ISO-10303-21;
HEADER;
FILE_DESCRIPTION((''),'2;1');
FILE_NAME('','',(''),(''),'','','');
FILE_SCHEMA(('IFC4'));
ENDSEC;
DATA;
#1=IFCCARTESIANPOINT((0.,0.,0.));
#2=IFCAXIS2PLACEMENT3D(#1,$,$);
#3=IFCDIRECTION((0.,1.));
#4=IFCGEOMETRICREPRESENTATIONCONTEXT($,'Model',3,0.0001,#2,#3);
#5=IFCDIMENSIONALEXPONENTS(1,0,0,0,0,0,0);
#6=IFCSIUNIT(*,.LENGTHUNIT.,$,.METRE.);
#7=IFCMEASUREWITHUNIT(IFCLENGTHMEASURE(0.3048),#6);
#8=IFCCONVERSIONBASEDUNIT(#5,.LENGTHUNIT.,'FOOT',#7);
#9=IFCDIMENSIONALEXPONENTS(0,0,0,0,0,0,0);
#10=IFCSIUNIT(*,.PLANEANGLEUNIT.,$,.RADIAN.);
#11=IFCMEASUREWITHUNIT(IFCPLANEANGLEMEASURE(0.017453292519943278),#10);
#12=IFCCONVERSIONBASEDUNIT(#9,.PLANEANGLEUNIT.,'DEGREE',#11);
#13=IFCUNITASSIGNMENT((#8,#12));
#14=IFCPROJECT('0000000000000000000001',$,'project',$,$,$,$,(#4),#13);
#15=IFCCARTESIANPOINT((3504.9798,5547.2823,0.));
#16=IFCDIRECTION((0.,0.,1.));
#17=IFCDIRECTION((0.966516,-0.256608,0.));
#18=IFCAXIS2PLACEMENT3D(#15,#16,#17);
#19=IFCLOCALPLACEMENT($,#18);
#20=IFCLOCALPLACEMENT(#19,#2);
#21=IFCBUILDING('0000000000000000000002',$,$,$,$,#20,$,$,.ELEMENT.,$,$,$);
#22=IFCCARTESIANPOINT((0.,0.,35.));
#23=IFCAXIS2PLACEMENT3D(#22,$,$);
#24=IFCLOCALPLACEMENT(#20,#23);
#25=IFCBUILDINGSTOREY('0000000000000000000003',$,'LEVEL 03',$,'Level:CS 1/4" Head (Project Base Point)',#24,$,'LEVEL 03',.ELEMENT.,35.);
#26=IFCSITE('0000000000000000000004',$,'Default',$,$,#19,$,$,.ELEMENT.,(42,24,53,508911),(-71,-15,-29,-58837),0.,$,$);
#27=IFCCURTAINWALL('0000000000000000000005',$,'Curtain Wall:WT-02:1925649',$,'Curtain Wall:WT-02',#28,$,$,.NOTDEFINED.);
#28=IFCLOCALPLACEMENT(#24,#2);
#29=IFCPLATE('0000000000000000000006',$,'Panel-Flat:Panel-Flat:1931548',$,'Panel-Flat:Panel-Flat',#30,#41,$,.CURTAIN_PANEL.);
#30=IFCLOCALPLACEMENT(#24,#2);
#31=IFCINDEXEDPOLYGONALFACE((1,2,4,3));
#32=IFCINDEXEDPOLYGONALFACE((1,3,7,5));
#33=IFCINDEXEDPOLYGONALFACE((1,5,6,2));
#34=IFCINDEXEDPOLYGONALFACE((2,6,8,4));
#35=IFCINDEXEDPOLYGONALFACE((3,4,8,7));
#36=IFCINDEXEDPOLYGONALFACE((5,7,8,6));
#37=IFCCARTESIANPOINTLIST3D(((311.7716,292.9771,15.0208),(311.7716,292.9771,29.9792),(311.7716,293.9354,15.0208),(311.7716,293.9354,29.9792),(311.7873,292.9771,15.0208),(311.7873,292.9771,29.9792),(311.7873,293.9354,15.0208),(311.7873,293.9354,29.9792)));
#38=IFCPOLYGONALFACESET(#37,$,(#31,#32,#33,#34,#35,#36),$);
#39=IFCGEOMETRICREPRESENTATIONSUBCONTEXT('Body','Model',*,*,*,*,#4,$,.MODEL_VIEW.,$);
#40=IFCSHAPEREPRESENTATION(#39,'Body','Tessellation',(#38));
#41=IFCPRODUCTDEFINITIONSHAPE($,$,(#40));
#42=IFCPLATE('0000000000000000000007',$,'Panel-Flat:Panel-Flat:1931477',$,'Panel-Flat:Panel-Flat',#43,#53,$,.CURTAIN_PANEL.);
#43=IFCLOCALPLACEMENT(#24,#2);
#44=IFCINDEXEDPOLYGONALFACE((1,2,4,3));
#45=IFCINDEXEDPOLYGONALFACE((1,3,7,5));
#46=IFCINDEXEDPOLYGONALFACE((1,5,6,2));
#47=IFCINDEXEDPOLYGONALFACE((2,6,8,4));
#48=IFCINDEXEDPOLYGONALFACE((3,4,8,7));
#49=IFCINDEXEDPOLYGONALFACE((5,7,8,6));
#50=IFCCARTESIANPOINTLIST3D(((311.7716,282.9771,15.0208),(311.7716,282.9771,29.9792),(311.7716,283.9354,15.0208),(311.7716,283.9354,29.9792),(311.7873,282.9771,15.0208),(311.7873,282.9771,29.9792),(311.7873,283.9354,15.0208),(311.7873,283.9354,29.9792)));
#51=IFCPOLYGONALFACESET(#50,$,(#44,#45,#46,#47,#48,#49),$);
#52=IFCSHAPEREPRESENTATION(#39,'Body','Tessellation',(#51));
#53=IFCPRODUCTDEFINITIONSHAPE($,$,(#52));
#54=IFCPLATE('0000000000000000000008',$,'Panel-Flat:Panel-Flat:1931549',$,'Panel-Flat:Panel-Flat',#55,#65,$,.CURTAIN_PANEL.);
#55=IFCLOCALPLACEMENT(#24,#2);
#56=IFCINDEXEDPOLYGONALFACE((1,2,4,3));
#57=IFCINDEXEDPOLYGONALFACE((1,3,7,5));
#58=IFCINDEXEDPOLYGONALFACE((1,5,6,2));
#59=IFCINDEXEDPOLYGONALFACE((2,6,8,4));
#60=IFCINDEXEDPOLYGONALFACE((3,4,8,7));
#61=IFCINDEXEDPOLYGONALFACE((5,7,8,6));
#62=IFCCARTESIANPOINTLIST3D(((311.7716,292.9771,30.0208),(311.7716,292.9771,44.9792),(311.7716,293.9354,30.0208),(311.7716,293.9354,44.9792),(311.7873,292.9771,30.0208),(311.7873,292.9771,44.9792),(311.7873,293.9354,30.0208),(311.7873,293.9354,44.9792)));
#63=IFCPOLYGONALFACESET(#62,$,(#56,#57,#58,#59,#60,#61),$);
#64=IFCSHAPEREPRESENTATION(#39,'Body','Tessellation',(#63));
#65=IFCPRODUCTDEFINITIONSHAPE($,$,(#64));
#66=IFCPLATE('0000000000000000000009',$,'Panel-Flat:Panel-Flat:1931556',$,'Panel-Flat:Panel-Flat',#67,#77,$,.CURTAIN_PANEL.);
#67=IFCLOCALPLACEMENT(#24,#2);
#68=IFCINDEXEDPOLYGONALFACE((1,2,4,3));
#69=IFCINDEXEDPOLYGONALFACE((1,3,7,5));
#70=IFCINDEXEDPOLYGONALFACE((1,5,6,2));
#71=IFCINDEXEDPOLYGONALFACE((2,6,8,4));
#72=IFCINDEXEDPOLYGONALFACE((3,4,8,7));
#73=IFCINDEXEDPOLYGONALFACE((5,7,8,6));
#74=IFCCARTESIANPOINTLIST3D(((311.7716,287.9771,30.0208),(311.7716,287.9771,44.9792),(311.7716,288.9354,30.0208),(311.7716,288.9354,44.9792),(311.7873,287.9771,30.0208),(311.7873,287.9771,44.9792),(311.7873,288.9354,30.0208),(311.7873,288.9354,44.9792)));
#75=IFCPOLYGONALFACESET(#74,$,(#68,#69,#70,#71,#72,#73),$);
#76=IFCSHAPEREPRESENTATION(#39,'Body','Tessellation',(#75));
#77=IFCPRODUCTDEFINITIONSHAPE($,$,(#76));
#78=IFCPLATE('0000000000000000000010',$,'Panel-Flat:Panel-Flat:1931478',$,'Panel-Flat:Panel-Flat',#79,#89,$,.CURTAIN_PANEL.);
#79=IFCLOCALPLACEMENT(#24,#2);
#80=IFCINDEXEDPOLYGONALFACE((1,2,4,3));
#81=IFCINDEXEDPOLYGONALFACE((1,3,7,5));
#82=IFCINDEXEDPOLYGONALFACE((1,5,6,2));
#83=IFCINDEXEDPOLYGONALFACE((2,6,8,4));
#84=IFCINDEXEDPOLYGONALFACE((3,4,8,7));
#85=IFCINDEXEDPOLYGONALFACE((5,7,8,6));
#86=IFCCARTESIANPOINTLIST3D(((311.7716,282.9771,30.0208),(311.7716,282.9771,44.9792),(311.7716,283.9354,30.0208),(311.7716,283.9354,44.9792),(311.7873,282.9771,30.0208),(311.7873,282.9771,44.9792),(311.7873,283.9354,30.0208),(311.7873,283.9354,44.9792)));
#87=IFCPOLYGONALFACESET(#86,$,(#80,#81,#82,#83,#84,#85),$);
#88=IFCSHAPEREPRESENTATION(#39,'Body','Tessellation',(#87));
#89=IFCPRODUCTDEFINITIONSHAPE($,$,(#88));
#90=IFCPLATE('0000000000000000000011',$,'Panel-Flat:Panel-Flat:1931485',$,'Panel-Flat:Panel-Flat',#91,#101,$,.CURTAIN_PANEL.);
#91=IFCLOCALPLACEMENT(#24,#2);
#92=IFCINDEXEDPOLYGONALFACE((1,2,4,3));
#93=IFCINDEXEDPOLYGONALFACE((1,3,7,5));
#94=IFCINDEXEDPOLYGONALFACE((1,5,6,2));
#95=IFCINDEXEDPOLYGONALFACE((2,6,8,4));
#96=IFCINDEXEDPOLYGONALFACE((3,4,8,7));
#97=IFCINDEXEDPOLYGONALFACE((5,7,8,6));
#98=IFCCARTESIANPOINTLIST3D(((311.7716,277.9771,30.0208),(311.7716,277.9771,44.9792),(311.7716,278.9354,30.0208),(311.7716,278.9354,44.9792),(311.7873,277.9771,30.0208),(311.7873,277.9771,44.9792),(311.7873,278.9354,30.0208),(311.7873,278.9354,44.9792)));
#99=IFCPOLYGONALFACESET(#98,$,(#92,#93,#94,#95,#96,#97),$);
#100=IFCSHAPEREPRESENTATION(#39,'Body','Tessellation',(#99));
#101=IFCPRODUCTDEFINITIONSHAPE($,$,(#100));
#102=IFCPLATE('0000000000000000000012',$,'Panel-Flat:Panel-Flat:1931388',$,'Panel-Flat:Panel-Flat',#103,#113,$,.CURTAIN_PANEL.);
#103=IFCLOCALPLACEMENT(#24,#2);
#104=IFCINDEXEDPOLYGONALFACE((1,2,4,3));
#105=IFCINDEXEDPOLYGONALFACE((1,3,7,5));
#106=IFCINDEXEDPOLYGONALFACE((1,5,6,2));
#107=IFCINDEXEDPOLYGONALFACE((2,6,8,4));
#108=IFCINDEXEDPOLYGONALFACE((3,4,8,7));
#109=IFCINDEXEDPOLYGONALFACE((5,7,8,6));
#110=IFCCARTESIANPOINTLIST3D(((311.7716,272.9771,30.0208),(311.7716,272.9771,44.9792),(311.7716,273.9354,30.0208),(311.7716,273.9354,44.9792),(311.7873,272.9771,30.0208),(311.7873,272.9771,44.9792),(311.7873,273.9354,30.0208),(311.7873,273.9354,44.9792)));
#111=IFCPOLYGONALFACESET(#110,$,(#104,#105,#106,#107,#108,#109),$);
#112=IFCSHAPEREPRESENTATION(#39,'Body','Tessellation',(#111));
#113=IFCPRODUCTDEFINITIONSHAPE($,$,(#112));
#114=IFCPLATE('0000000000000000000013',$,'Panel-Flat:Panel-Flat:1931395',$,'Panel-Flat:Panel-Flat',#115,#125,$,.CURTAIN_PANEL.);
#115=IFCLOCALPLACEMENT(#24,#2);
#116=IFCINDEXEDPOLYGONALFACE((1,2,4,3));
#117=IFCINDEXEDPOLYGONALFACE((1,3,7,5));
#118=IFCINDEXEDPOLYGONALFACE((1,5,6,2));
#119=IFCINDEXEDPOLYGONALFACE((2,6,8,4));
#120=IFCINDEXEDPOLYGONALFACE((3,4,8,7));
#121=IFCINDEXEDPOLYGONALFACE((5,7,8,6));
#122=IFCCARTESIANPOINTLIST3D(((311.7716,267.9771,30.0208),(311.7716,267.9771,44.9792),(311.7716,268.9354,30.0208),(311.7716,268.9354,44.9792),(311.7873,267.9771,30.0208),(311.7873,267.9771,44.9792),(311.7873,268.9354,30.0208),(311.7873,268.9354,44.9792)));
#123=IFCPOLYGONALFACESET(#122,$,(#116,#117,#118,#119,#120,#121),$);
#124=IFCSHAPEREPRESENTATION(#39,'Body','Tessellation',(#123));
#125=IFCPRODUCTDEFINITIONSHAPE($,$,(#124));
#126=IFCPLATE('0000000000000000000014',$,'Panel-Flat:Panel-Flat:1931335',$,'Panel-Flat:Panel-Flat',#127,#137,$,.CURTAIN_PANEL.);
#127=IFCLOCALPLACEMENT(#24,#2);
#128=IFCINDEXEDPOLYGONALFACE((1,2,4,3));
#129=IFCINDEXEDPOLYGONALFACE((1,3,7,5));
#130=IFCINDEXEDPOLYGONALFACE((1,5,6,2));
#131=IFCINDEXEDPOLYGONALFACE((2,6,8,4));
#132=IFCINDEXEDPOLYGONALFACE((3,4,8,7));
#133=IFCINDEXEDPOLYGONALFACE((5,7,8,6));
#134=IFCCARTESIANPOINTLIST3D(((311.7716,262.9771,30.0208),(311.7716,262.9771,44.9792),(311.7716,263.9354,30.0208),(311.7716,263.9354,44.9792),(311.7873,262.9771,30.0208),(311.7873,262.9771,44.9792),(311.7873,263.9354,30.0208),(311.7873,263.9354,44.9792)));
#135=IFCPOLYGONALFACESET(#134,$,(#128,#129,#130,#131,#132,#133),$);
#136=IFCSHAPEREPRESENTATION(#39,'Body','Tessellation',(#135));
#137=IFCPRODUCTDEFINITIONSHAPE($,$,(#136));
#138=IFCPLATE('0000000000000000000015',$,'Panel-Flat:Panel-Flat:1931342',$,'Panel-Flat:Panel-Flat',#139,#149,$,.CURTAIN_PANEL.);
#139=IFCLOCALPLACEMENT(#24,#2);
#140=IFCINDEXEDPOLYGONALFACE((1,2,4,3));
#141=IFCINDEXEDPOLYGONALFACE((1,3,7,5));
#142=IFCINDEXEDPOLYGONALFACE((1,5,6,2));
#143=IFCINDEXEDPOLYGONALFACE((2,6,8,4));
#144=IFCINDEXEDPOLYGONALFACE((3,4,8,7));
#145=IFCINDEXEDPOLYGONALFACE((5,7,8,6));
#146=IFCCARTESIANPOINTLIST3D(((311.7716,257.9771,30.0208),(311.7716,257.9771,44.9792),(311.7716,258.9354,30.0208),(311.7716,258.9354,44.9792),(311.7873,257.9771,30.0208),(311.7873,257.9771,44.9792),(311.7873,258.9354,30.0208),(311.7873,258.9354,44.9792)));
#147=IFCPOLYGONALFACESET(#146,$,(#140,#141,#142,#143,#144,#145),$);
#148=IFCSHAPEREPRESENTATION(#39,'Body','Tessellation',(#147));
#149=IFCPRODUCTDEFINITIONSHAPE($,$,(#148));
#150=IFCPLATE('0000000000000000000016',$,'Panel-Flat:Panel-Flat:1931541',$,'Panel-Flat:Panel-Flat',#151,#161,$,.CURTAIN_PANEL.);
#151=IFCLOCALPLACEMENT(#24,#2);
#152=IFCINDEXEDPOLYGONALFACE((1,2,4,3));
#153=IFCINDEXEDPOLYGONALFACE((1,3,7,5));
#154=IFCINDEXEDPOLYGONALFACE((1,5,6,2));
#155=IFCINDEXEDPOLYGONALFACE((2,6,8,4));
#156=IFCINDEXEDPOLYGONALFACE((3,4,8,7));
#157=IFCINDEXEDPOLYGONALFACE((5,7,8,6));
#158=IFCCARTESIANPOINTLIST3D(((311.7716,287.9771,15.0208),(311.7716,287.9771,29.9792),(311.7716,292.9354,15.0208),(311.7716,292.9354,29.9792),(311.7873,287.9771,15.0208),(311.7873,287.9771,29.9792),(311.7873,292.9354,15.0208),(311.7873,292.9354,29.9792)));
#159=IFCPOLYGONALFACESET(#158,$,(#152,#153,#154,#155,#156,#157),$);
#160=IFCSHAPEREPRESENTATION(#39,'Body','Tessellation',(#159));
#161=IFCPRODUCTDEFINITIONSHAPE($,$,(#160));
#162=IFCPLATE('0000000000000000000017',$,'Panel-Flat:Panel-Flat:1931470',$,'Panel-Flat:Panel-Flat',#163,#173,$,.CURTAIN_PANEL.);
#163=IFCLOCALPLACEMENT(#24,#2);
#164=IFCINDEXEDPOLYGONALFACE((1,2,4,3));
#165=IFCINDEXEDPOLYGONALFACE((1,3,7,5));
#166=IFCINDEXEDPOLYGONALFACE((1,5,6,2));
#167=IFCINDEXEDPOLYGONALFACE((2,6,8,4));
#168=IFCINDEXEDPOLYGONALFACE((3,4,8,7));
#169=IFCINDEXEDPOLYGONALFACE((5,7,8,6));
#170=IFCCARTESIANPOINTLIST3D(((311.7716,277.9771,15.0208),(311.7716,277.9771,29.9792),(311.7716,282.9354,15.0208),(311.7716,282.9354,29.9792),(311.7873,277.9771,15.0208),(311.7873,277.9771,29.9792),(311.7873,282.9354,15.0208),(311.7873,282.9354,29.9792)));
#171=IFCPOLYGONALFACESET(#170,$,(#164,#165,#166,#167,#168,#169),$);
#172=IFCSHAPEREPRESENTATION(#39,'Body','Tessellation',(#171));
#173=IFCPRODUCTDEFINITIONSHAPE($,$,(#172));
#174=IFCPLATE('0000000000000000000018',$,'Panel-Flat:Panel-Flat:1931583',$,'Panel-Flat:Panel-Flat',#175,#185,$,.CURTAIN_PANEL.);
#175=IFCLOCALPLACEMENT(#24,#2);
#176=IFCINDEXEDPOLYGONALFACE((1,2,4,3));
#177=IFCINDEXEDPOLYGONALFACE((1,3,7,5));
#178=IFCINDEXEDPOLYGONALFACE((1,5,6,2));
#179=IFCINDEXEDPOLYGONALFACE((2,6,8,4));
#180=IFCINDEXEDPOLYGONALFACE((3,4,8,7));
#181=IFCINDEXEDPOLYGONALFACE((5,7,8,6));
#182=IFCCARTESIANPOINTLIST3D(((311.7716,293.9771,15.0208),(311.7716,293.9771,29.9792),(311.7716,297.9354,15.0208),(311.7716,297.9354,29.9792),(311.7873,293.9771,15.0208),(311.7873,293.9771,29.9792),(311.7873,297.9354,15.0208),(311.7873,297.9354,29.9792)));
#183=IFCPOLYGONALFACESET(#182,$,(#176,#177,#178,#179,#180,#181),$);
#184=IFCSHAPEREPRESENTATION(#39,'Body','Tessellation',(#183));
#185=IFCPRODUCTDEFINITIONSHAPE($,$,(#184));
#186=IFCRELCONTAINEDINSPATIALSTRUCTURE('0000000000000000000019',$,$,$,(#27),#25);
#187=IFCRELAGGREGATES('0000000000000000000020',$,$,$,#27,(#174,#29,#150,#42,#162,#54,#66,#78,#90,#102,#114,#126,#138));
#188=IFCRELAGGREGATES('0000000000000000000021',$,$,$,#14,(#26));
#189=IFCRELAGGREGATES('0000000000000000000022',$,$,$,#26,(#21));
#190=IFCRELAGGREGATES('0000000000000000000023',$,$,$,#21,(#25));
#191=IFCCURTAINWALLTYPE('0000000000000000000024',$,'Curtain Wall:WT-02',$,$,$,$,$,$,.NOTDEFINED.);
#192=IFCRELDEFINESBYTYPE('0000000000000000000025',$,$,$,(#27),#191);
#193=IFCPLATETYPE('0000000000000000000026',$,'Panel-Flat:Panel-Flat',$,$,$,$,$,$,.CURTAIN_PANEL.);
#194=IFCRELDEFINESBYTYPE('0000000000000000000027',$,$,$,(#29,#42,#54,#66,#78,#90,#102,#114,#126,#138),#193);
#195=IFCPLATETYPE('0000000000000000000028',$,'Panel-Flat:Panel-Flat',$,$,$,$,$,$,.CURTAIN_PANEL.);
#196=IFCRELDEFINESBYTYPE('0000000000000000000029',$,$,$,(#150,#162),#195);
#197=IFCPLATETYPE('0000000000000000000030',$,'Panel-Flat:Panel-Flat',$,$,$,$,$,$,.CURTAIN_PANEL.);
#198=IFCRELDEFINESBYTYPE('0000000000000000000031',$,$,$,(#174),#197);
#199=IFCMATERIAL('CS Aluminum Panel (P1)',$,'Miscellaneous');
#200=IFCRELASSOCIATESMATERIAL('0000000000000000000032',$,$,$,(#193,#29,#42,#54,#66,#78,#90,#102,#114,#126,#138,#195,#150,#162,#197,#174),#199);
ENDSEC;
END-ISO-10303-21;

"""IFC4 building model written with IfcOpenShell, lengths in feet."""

from ifc_helpers import new_model, entity, si_unit, converted_unit, direction, frame, origin, place, context, subcontext, project, spatial, indexed_curve, outline, extrude, source, transform, mapped, material, type_object, type_shapes, element, aggregate, save


model = new_model("IFC4")

# Units and contexts
model_context = context("Model", 3, precision=0.0001, world=origin(), true_north=direction((0.0, 1.0)))
body_context = subcontext(model_context, "Body", "Model", "MODEL_VIEW")
ifc_project = project(units=[converted_unit("LENGTHUNIT", "FOOT", entity("IfcLengthMeasure", 0.3048), si_unit("LENGTHUNIT", "METRE"), dimensions=[1, 0, 0, 0, 0, 0, 0]), converted_unit("PLANEANGLEUNIT", "DEGREE", entity("IfcPlaneAngleMeasure", 0.017453292519943278), si_unit("PLANEANGLEUNIT", "RADIAN"), dimensions=[0, 0, 0, 0, 0, 0, 0])], contexts=[model_context])

# Site, building, storey
site_placement = place(None, frame((3504.9798, 5547.2823, 0.0), z_axis=(0.0, 0.0, 1.0), x_axis=(0.966516, -0.256608, 0.0)))
site = spatial("IfcSite", under=ifc_project, at=site_placement, Name="Default", CompositionType="ELEMENT", RefLatitude=(42, 24, 53, 508911), RefLongitude=(-71, -15, -29, -58837), RefElevation=0.0)
building_placement = place(site_placement, origin())
building = spatial("IfcBuilding", under=site, at=building_placement, CompositionType="ELEMENT")
storey_placement = place(building_placement, frame((0.0, 0.0, 35.0)))
storey = spatial("IfcBuildingStorey", under=building, at=storey_placement, Name="LEVEL 03", ObjectType="Level:CS 1/4\" Head (Project Base Point)", LongName="LEVEL 03", CompositionType="ELEMENT", Elevation=35.0)

# Curtain wall, plates
curtain_wall_type = type_object("IfcCurtainWallType", Name="Curtain Wall:WT-02", PredefinedType="NOTDEFINED")
curtain_wall_placement = place(storey_placement, frame((0.0, 0.0, -35.0)))
curtain_wall = element("IfcCurtainWall", 1, at=curtain_wall_placement, inside=storey, type_object=curtain_wall_type, Name="Curtain Wall:WT-02:1925649", ObjectType="Curtain Wall:WT-02", PredefinedType="NOTDEFINED")
ifc_material = material(Name="CS Aluminum Panel (P1)", Category="Miscellaneous")
plate_type_1 = type_object("IfcPlateType", Name="Panel-Flat:Panel-Flat", PredefinedType="CURTAIN_PANEL", material=ifc_material)
shared_shape_1 = source(origin(), body_context, "Body", "SweptSolid", [
    extrude(outline(indexed_curve([(-0.0078, -0.4792), (0.0078, -0.4792), (0.0078, 0.4792), (-0.0078, 0.4792), (-0.0078, -0.4792)], self_intersect=False)), frame((0.0, -0.0078, 0.0208), z_axis=(0.0, 0.0, 1.0), x_axis=(0.0, -1.0, 0.0)), (0.0, 0.0, 1.0), 14.9583),
])
type_shapes(plate_type_1, [shared_shape_1])
plate_1_placement = place(curtain_wall_placement, frame((311.7873, 293.4563, 50.0), z_axis=(0.0, 0.0, 1.0), x_axis=(0.0, -1.0, 0.0)))
plate_1 = element("IfcPlate", 2, at=plate_1_placement, type_object=plate_type_1, material=ifc_material, Name="Panel-Flat:Panel-Flat:1931548", ObjectType="Panel-Flat:Panel-Flat", PredefinedType="CURTAIN_PANEL", context=body_context, shape_type="MappedRepresentation", body=[
    mapped(shared_shape_1, transform((0.0, 0.0, 0.0), scale=1.0)),
])
plate_2_placement = place(curtain_wall_placement, frame((311.7873, 283.4563, 50.0), z_axis=(0.0, 0.0, 1.0), x_axis=(0.0, -1.0, 0.0)))
plate_2 = element("IfcPlate", 3, at=plate_2_placement, type_object=plate_type_1, material=ifc_material, Name="Panel-Flat:Panel-Flat:1931477", ObjectType="Panel-Flat:Panel-Flat", PredefinedType="CURTAIN_PANEL", context=body_context, shape_type="MappedRepresentation", body=[
    mapped(shared_shape_1, transform((0.0, 0.0, 0.0), scale=1.0)),
])
plate_3_placement = place(curtain_wall_placement, frame((311.7873, 293.4563, 65.0), z_axis=(0.0, 0.0, 1.0), x_axis=(0.0, -1.0, 0.0)))
plate_3 = element("IfcPlate", 4, at=plate_3_placement, type_object=plate_type_1, material=ifc_material, Name="Panel-Flat:Panel-Flat:1931549", ObjectType="Panel-Flat:Panel-Flat", PredefinedType="CURTAIN_PANEL", context=body_context, shape_type="MappedRepresentation", body=[
    mapped(shared_shape_1, transform((0.0, 0.0, 0.0), scale=1.0)),
])
plate_4_placement = place(curtain_wall_placement, frame((311.7873, 288.4563, 65.0), z_axis=(0.0, 0.0, 1.0), x_axis=(0.0, -1.0, 0.0)))
plate_4 = element("IfcPlate", 5, at=plate_4_placement, type_object=plate_type_1, material=ifc_material, Name="Panel-Flat:Panel-Flat:1931556", ObjectType="Panel-Flat:Panel-Flat", PredefinedType="CURTAIN_PANEL", context=body_context, shape_type="MappedRepresentation", body=[
    mapped(shared_shape_1, transform((0.0, 0.0, 0.0), scale=1.0)),
])
plate_5_placement = place(curtain_wall_placement, frame((311.7873, 283.4563, 65.0), z_axis=(0.0, 0.0, 1.0), x_axis=(0.0, -1.0, 0.0)))
plate_5 = element("IfcPlate", 6, at=plate_5_placement, type_object=plate_type_1, material=ifc_material, Name="Panel-Flat:Panel-Flat:1931478", ObjectType="Panel-Flat:Panel-Flat", PredefinedType="CURTAIN_PANEL", context=body_context, shape_type="MappedRepresentation", body=[
    mapped(shared_shape_1, transform((0.0, 0.0, 0.0), scale=1.0)),
])
plate_6_placement = place(curtain_wall_placement, frame((311.7873, 278.4563, 65.0), z_axis=(0.0, 0.0, 1.0), x_axis=(0.0, -1.0, 0.0)))
plate_6 = element("IfcPlate", 7, at=plate_6_placement, type_object=plate_type_1, material=ifc_material, Name="Panel-Flat:Panel-Flat:1931485", ObjectType="Panel-Flat:Panel-Flat", PredefinedType="CURTAIN_PANEL", context=body_context, shape_type="MappedRepresentation", body=[
    mapped(shared_shape_1, transform((0.0, 0.0, 0.0), scale=1.0)),
])
plate_7_placement = place(curtain_wall_placement, frame((311.7873, 273.4563, 65.0), z_axis=(0.0, 0.0, 1.0), x_axis=(0.0, -1.0, 0.0)))
plate_7 = element("IfcPlate", 8, at=plate_7_placement, type_object=plate_type_1, material=ifc_material, Name="Panel-Flat:Panel-Flat:1931388", ObjectType="Panel-Flat:Panel-Flat", PredefinedType="CURTAIN_PANEL", context=body_context, shape_type="MappedRepresentation", body=[
    mapped(shared_shape_1, transform((0.0, 0.0, 0.0), scale=1.0)),
])
plate_8_placement = place(curtain_wall_placement, frame((311.7873, 268.4563, 65.0), z_axis=(0.0, 0.0, 1.0), x_axis=(0.0, -1.0, 0.0)))
plate_8 = element("IfcPlate", 9, at=plate_8_placement, type_object=plate_type_1, material=ifc_material, Name="Panel-Flat:Panel-Flat:1931395", ObjectType="Panel-Flat:Panel-Flat", PredefinedType="CURTAIN_PANEL", context=body_context, shape_type="MappedRepresentation", body=[
    mapped(shared_shape_1, transform((0.0, 0.0, 0.0), scale=1.0)),
])
plate_9_placement = place(curtain_wall_placement, frame((311.7873, 263.4563, 65.0), z_axis=(0.0, 0.0, 1.0), x_axis=(0.0, -1.0, 0.0)))
plate_9 = element("IfcPlate", 10, at=plate_9_placement, type_object=plate_type_1, material=ifc_material, Name="Panel-Flat:Panel-Flat:1931335", ObjectType="Panel-Flat:Panel-Flat", PredefinedType="CURTAIN_PANEL", context=body_context, shape_type="MappedRepresentation", body=[
    mapped(shared_shape_1, transform((0.0, 0.0, 0.0), scale=1.0)),
])
plate_10_placement = place(curtain_wall_placement, frame((311.7873, 258.4563, 65.0), z_axis=(0.0, 0.0, 1.0), x_axis=(0.0, -1.0, 0.0)))
plate_10 = element("IfcPlate", 11, at=plate_10_placement, type_object=plate_type_1, material=ifc_material, Name="Panel-Flat:Panel-Flat:1931342", ObjectType="Panel-Flat:Panel-Flat", PredefinedType="CURTAIN_PANEL", context=body_context, shape_type="MappedRepresentation", body=[
    mapped(shared_shape_1, transform((0.0, 0.0, 0.0), scale=1.0)),
])
plate_type_2 = type_object("IfcPlateType", Name="Panel-Flat:Panel-Flat", PredefinedType="CURTAIN_PANEL", material=ifc_material)
shared_shape_2 = source(origin(), body_context, "Body", "SweptSolid", [
    extrude(outline(indexed_curve([(-0.0078, -2.4792), (0.0078, -2.4792), (0.0078, 2.4792), (-0.0078, 2.4792), (-0.0078, -2.4792)], self_intersect=False)), frame((0.0, -0.0078, 0.0208), z_axis=(0.0, 0.0, 1.0), x_axis=(0.0, -1.0, 0.0)), (0.0, 0.0, 1.0), 14.9583),
])
type_shapes(plate_type_2, [shared_shape_2])
plate_11_placement = place(curtain_wall_placement, frame((311.7873, 290.4563, 50.0), z_axis=(0.0, 0.0, 1.0), x_axis=(0.0, -1.0, 0.0)))
plate_11 = element("IfcPlate", 12, at=plate_11_placement, type_object=plate_type_2, material=ifc_material, Name="Panel-Flat:Panel-Flat:1931541", ObjectType="Panel-Flat:Panel-Flat", PredefinedType="CURTAIN_PANEL", context=body_context, shape_type="MappedRepresentation", body=[
    mapped(shared_shape_2, transform((0.0, 0.0, 0.0), scale=1.0)),
])
plate_12_placement = place(curtain_wall_placement, frame((311.7873, 280.4563, 50.0), z_axis=(0.0, 0.0, 1.0), x_axis=(0.0, -1.0, 0.0)))
plate_12 = element("IfcPlate", 13, at=plate_12_placement, type_object=plate_type_2, material=ifc_material, Name="Panel-Flat:Panel-Flat:1931470", ObjectType="Panel-Flat:Panel-Flat", PredefinedType="CURTAIN_PANEL", context=body_context, shape_type="MappedRepresentation", body=[
    mapped(shared_shape_2, transform((0.0, 0.0, 0.0), scale=1.0)),
])
plate_type_3 = type_object("IfcPlateType", Name="Panel-Flat:Panel-Flat", PredefinedType="CURTAIN_PANEL", material=ifc_material)
shared_shape_3 = source(origin(), body_context, "Body", "SweptSolid", [
    extrude(outline(indexed_curve([(-0.0078, -1.9792), (0.0078, -1.9792), (0.0078, 1.9792), (-0.0078, 1.9792), (-0.0078, -1.9792)], self_intersect=False)), frame((0.0, -0.0078, 0.0208), z_axis=(0.0, 0.0, 1.0), x_axis=(0.0, -1.0, 0.0)), (0.0, 0.0, 1.0), 14.9583),
])
type_shapes(plate_type_3, [shared_shape_3])
plate_13_placement = place(curtain_wall_placement, frame((311.7873, 295.9563, 50.0), z_axis=(0.0, 0.0, 1.0), x_axis=(0.0, -1.0, 0.0)))
plate_13 = element("IfcPlate", 14, at=plate_13_placement, type_object=plate_type_3, material=ifc_material, Name="Panel-Flat:Panel-Flat:1931583", ObjectType="Panel-Flat:Panel-Flat", PredefinedType="CURTAIN_PANEL", context=body_context, shape_type="MappedRepresentation", body=[
    mapped(shared_shape_3, transform((0.0, 0.0, 0.0), scale=1.0)),
])
aggregate(curtain_wall, [plate_13, plate_1, plate_11, plate_2, plate_12, plate_3, plate_4, plate_5, plate_6, plate_7, plate_8, plate_9, plate_10])

save(model, "model.ifc")
